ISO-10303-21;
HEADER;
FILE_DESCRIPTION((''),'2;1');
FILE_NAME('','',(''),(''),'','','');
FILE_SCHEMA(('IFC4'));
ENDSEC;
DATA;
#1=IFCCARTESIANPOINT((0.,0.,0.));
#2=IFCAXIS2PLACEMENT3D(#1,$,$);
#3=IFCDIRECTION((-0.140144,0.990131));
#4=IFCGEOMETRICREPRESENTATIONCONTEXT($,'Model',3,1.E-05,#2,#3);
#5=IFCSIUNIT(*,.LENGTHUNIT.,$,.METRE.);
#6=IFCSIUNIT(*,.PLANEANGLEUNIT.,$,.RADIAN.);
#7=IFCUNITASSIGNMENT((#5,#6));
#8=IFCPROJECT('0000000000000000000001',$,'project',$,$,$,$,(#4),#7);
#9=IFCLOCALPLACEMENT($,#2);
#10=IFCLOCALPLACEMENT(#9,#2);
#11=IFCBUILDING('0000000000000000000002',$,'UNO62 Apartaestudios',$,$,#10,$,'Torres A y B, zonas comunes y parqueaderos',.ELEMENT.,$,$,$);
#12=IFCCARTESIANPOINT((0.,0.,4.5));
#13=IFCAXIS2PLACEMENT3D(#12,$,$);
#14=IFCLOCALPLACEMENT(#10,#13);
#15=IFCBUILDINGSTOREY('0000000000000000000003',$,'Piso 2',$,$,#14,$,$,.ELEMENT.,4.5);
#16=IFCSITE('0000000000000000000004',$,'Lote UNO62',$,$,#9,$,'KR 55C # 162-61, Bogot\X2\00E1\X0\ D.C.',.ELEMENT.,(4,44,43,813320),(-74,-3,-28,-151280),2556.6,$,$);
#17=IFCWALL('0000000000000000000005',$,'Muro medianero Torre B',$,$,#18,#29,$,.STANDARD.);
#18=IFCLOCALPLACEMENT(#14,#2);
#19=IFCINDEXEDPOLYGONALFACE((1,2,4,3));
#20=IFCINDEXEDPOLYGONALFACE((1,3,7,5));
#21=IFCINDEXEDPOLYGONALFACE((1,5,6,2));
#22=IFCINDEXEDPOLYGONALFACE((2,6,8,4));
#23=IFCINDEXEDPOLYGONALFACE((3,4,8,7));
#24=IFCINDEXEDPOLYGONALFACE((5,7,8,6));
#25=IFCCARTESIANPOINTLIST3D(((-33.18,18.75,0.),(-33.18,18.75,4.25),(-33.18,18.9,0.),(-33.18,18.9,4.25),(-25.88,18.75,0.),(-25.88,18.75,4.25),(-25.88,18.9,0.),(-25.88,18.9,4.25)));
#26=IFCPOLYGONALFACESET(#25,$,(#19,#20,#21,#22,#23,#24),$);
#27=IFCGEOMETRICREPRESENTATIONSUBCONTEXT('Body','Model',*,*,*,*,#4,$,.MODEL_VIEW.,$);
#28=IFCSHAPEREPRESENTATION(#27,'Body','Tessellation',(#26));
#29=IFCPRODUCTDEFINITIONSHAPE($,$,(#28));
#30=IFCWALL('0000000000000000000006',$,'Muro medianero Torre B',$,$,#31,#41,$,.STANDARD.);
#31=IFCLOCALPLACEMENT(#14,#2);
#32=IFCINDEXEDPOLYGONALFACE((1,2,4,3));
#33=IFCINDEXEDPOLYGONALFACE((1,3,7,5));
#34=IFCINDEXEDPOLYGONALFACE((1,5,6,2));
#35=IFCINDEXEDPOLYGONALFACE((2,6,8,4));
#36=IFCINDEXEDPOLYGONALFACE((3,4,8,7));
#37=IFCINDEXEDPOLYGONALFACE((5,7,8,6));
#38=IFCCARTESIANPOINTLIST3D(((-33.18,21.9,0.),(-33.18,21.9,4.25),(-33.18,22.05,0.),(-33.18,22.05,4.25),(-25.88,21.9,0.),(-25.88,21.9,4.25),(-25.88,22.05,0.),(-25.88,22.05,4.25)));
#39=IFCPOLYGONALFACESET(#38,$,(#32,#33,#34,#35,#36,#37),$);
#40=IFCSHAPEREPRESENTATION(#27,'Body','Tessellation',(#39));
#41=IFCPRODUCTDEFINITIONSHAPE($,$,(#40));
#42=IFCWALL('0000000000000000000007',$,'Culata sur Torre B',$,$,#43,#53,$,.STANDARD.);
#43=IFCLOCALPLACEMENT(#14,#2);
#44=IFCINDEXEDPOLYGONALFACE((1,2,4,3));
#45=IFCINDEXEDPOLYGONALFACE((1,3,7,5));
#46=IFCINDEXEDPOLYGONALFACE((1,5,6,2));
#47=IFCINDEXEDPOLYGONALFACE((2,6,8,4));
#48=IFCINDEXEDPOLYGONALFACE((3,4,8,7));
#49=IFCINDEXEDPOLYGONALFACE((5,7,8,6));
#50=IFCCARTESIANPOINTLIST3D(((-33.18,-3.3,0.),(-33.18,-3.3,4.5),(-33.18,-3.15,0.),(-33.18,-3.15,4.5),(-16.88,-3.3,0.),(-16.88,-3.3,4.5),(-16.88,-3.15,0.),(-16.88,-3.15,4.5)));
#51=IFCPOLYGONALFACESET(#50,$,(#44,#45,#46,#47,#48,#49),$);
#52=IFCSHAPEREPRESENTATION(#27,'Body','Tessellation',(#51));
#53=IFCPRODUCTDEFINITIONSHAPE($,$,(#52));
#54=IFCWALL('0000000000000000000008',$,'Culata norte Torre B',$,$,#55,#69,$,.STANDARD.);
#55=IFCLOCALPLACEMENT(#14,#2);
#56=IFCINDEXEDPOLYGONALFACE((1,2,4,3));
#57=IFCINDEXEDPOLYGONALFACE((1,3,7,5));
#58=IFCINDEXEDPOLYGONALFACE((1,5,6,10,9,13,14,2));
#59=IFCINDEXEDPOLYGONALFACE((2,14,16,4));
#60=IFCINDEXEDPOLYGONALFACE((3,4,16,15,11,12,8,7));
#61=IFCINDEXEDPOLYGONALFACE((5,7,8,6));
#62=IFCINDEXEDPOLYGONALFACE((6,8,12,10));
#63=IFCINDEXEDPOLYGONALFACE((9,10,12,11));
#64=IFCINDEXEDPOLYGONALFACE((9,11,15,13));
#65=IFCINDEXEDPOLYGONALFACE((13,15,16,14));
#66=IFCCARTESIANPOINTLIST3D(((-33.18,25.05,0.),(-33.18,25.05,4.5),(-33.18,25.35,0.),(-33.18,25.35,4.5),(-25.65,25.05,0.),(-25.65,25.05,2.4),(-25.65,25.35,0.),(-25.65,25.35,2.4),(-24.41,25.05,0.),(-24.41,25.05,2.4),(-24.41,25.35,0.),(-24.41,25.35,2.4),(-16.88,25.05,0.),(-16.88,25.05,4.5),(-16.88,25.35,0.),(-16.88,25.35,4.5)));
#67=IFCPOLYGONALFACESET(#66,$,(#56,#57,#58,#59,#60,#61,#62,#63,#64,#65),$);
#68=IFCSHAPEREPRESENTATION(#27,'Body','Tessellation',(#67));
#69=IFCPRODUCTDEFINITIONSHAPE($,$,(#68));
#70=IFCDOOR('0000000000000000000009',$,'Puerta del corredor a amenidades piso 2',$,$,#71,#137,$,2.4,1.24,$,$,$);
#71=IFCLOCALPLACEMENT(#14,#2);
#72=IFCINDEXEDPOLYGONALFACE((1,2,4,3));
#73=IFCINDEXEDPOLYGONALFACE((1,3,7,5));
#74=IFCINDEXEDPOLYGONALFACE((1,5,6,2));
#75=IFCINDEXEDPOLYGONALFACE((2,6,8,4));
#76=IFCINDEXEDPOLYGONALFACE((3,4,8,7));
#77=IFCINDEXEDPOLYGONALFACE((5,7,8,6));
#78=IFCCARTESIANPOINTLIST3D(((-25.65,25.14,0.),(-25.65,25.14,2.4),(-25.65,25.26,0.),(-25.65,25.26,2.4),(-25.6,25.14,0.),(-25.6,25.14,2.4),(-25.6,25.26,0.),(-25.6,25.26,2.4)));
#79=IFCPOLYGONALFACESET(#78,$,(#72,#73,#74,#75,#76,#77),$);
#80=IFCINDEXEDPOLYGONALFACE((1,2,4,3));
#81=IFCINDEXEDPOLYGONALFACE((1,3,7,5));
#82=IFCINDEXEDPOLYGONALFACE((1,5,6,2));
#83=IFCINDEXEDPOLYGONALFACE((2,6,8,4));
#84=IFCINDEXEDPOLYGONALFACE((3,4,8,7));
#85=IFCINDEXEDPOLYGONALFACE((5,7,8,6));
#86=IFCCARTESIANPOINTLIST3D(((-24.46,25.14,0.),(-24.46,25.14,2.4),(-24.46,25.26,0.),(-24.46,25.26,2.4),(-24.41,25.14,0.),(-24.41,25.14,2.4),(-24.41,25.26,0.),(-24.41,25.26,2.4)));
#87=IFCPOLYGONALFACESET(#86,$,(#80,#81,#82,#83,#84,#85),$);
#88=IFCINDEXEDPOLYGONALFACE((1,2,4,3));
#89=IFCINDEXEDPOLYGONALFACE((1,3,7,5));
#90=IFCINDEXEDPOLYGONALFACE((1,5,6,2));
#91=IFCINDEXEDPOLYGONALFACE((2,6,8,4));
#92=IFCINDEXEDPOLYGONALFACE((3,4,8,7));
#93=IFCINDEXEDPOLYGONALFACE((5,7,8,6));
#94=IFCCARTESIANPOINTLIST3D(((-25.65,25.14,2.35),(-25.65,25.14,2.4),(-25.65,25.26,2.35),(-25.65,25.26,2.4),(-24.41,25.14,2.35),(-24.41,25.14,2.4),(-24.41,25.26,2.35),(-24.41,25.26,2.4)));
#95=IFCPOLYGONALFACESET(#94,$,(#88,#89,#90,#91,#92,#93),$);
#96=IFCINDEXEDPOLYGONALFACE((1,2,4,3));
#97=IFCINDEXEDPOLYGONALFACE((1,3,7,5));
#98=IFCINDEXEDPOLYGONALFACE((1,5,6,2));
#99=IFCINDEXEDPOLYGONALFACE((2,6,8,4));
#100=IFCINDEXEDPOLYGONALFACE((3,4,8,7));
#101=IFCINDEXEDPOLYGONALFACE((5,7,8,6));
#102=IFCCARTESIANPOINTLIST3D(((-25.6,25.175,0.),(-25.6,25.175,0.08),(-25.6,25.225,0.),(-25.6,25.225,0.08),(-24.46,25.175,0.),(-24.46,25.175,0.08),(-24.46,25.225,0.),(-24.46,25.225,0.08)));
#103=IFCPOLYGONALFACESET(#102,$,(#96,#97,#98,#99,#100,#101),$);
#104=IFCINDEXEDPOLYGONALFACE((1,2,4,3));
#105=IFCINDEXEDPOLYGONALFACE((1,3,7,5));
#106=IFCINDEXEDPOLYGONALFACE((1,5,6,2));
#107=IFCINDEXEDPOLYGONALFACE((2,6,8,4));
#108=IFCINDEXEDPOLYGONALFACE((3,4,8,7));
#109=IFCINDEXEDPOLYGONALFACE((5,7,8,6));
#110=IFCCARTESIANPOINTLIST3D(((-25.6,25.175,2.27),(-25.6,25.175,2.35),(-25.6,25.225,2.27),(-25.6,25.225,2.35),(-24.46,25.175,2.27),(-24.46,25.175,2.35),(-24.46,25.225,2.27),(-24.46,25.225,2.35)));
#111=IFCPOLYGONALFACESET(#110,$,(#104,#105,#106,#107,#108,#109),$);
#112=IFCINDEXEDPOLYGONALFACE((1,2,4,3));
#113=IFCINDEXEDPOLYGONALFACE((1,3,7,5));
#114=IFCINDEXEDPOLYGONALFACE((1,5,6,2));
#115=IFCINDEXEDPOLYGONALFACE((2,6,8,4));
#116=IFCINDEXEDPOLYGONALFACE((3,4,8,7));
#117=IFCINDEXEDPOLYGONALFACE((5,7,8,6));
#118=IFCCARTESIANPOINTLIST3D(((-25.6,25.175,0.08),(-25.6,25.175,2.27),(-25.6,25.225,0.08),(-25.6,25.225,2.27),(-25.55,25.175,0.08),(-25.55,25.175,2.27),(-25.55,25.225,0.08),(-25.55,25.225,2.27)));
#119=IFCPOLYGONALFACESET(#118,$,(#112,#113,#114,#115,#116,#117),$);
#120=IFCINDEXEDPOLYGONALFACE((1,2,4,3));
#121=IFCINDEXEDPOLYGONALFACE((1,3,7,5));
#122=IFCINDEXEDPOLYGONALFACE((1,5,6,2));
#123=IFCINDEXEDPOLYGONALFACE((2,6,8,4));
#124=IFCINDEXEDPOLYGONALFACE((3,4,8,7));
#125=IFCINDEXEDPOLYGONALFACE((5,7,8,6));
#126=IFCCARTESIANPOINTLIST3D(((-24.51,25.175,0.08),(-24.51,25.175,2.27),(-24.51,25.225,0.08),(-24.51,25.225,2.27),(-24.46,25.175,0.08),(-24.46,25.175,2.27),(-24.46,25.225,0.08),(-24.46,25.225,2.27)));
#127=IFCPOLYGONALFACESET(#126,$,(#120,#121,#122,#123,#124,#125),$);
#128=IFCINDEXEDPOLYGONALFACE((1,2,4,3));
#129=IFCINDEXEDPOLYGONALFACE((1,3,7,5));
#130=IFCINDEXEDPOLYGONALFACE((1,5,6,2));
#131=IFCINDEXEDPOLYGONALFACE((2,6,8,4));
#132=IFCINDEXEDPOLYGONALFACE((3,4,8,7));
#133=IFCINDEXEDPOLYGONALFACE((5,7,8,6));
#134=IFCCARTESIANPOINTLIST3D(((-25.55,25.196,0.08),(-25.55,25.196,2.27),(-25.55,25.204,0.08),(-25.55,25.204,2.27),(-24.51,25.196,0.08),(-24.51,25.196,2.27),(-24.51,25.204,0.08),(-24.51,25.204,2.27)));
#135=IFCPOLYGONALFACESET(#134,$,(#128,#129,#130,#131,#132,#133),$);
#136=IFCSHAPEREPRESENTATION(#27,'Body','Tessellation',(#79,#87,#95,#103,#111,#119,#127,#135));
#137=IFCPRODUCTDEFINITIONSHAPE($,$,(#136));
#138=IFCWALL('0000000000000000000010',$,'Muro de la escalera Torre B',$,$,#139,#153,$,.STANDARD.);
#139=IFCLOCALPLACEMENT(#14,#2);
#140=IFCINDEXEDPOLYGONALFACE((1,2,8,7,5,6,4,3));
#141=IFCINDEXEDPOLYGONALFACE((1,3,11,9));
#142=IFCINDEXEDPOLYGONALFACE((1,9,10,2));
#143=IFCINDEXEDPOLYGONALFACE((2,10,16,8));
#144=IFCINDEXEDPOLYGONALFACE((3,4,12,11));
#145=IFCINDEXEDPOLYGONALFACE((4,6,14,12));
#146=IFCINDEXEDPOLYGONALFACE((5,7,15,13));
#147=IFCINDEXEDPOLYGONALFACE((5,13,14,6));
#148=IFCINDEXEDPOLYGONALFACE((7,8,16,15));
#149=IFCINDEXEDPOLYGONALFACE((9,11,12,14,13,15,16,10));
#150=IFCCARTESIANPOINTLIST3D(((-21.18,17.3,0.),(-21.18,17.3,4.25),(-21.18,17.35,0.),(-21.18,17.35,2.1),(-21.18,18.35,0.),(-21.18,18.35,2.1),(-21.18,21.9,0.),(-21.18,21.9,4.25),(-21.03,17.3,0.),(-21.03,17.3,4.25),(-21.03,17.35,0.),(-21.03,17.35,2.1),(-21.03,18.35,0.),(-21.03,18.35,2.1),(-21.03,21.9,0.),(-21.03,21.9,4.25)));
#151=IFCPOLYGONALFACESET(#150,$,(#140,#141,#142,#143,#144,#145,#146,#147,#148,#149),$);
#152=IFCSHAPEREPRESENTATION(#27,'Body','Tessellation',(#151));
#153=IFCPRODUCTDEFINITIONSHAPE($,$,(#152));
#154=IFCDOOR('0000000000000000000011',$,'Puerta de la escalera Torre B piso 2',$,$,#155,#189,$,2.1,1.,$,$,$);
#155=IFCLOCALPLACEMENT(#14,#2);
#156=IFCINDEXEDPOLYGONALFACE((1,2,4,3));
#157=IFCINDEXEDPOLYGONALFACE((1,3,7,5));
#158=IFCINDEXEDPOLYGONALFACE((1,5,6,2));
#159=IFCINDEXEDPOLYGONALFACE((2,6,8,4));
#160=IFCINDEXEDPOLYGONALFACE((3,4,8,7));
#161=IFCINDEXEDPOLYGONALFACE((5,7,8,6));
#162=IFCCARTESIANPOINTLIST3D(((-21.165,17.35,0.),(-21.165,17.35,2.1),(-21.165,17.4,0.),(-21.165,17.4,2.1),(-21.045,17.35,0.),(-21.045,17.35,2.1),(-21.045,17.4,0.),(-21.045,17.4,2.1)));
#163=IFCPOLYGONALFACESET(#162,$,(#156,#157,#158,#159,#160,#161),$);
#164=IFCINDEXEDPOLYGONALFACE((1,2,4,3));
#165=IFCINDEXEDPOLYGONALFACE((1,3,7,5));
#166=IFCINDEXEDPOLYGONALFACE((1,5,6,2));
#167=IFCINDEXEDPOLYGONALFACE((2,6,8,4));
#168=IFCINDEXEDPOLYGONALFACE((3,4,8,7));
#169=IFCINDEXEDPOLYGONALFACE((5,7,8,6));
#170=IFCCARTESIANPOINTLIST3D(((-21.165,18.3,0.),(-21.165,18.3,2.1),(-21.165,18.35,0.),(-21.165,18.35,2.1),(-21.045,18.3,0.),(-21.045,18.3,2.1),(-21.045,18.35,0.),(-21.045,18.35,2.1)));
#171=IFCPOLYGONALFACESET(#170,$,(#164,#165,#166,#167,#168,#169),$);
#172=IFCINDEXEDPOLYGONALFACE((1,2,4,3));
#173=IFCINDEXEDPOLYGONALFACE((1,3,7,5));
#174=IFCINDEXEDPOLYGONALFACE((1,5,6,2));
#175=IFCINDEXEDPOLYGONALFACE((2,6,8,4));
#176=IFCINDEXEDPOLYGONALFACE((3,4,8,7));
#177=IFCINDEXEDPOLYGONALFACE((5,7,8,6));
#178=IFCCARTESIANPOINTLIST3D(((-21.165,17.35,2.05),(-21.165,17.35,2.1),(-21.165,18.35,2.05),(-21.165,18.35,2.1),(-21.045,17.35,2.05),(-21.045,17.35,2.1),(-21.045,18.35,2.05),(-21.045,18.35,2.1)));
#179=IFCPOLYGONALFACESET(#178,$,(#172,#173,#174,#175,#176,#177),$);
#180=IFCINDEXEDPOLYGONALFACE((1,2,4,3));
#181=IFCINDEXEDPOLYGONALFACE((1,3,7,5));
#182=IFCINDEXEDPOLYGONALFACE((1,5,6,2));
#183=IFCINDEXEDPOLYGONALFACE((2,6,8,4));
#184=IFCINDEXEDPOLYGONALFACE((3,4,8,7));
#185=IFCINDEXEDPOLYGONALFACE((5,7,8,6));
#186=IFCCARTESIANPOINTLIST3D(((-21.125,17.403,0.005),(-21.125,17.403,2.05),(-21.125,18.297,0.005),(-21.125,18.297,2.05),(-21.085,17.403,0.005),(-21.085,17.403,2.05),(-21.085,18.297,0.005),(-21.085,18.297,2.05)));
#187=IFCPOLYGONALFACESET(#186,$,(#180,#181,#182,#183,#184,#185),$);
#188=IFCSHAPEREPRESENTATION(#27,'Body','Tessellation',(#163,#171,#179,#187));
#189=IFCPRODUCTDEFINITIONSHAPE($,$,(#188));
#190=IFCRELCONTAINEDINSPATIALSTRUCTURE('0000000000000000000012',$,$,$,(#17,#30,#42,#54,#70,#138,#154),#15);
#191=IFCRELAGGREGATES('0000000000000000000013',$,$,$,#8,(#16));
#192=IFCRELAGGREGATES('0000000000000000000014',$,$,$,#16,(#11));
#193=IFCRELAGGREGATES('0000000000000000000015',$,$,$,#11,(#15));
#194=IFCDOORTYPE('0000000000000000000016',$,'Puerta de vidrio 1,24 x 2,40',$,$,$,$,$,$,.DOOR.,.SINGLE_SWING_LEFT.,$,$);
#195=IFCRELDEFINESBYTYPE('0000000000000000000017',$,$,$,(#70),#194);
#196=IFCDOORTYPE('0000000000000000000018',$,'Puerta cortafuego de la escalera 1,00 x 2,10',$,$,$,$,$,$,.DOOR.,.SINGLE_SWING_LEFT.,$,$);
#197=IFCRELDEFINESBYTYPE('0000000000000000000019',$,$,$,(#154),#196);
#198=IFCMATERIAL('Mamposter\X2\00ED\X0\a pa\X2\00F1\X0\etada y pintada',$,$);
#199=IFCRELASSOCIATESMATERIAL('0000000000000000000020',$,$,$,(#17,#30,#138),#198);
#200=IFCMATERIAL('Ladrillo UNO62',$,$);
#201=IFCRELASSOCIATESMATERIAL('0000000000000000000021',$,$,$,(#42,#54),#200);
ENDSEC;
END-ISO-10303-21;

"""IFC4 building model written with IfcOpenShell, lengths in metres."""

from ifc_helpers import new_model, si_unit, direction, frame, frame_2d, origin, place, context, subcontext, project, spatial, rectangle, extrude, source, transform, mapped, material, type_object, type_shapes, element, fill, save


model = new_model("IFC4")

# Units and contexts
model_context = context("Model", 3, precision=1e-05, world=origin(), true_north=direction((-0.140144, 0.990131)))
body_context = subcontext(model_context, "Body", "Model", "MODEL_VIEW")
ifc_project = project(units=[si_unit("LENGTHUNIT", "METRE"), si_unit("PLANEANGLEUNIT", "RADIAN")], contexts=[model_context])

# Site, building, storey
site_placement = place(None, origin())
site = spatial("IfcSite", under=ifc_project, at=site_placement, Name="Lote UNO62", LongName="KR 55C # 162-61, Bogotá D.C.", CompositionType="ELEMENT", RefLatitude=(4, 44, 43, 813320), RefLongitude=(-74, -3, -28, -151280), RefElevation=2556.6)
building_placement = place(site_placement, origin())
building = spatial("IfcBuilding", under=site, at=building_placement, Name="UNO62 Apartaestudios", LongName="Torres A y B, zonas comunes y parqueaderos", CompositionType="ELEMENT")
storey_placement = place(building_placement, frame((0.0, 0.0, 4.5)))
storey = spatial("IfcBuildingStorey", under=building, at=storey_placement, Name="Piso 2", CompositionType="ELEMENT", Elevation=4.5)

# Shared definitions
ifc_material_1 = material(Name="Ladrillo UNO62")

# Walls
ifc_material_2 = material(Name="Mampostería pañetada y pintada")
wall_1_placement = place(storey_placement, origin())
element("IfcWall", 1, at=wall_1_placement, inside=storey, material=ifc_material_2, Name="Muro medianero Torre B", PredefinedType="STANDARD", context=body_context, shape_type="SweptSolid", body=[
    extrude(rectangle(XDim=7.3, YDim=0.15, at=frame_2d((-29.53, 18.825))), origin(), (0.0, 0.0, 1.0), 4.25),
])
wall_2_placement = place(storey_placement, origin())
element("IfcWall", 2, at=wall_2_placement, inside=storey, material=ifc_material_2, Name="Muro medianero Torre B", PredefinedType="STANDARD", context=body_context, shape_type="SweptSolid", body=[
    extrude(rectangle(XDim=7.3, YDim=0.15, at=frame_2d((-29.53, 21.975))), origin(), (0.0, 0.0, 1.0), 4.25),
])
wall_3_placement = place(storey_placement, origin())
element("IfcWall", 3, at=wall_3_placement, inside=storey, material=ifc_material_1, Name="Culata sur Torre B", PredefinedType="STANDARD", context=body_context, shape_type="SweptSolid", body=[
    extrude(rectangle(XDim=16.3, YDim=0.15, at=frame_2d((-25.03, -3.225))), origin(), (0.0, 0.0, 1.0), 4.5),
])

# Walls, openings, doors
wall_4_placement = place(storey_placement, origin())
wall_4 = element("IfcWall", 4, at=wall_4_placement, inside=storey, material=ifc_material_1, Name="Culata norte Torre B", PredefinedType="STANDARD", context=body_context, shape_type="SweptSolid", body=[
    extrude(rectangle(XDim=16.3, YDim=0.3, at=frame_2d((-25.03, 25.2))), origin(), (0.0, 0.0, 1.0), 4.5),
])
opening_1_placement = place(wall_4_placement, origin())
opening_1 = element("IfcOpeningElement", 5, at=opening_1_placement, cuts=wall_4, PredefinedType="OPENING", context=body_context, shape_type="SweptSolid", body=[
    extrude(rectangle(XDim=1.24, YDim=0.4, at=frame_2d((-25.03, 25.2))), origin(), (0.0, 0.0, 1.0), 2.4),
])
door_type_1 = type_object("IfcDoorType", Name="Puerta de vidrio 1,24 x 2,40", OperationType="SINGLE_SWING_LEFT", PredefinedType="DOOR")
shared_shape_1 = source(origin(), body_context, "Body", "SweptSolid", [
    extrude(rectangle(XDim=0.05, YDim=0.12, at=frame_2d((0.025, 0.0))), origin(), (0.0, 0.0, 1.0), 2.4),
    extrude(rectangle(XDim=0.05, YDim=0.12, at=frame_2d((1.215, 0.0))), origin(), (0.0, 0.0, 1.0), 2.4),
    extrude(rectangle(XDim=1.24, YDim=0.12, at=frame_2d((0.62, 0.0))), frame((0.0, 0.0, 2.35)), (0.0, 0.0, 1.0), 0.05),
    extrude(rectangle(XDim=1.14, YDim=0.05, at=frame_2d((0.62, 0.0))), origin(), (0.0, 0.0, 1.0), 0.08),
    extrude(rectangle(XDim=1.14, YDim=0.05, at=frame_2d((0.62, 0.0))), frame((0.0, 0.0, 2.27)), (0.0, 0.0, 1.0), 0.08),
    extrude(rectangle(XDim=0.05, YDim=0.05, at=frame_2d((0.075, 0.0))), frame((0.0, 0.0, 0.08)), (0.0, 0.0, 1.0), 2.19),
    extrude(rectangle(XDim=0.05, YDim=0.05, at=frame_2d((1.165, 0.0))), frame((0.0, 0.0, 0.08)), (0.0, 0.0, 1.0), 2.19),
    extrude(rectangle(XDim=1.04, YDim=0.008, at=frame_2d((0.62, 0.0))), frame((0.0, 0.0, 0.08)), (0.0, 0.0, 1.0), 2.19),
])
type_shapes(door_type_1, [shared_shape_1])
door_1_placement = place(storey_placement, frame((-25.65, 25.2, 0.0), z_axis=(0.0, 0.0, 1.0), x_axis=(1.0, 0.0, 0.0)))
door_1 = element("IfcDoor", 6, at=door_1_placement, inside=storey, type_object=door_type_1, Name="Puerta del corredor a amenidades piso 2", OverallHeight=2.4, OverallWidth=1.24, context=body_context, shape_type="MappedRepresentation", body=[
    mapped(shared_shape_1, transform((0.0, 0.0, 0.0))),
])
fill(opening_1, door_1)
wall_5_placement = place(storey_placement, origin())
wall_5 = element("IfcWall", 7, at=wall_5_placement, inside=storey, material=ifc_material_2, Name="Muro de la escalera Torre B", PredefinedType="STANDARD", context=body_context, shape_type="SweptSolid", body=[
    extrude(rectangle(XDim=0.15, YDim=4.6, at=frame_2d((-21.105, 19.6))), origin(), (0.0, 0.0, 1.0), 4.25),
])
opening_2_placement = place(wall_5_placement, origin())
opening_2 = element("IfcOpeningElement", 8, at=opening_2_placement, cuts=wall_5, PredefinedType="OPENING", context=body_context, shape_type="SweptSolid", body=[
    extrude(rectangle(XDim=0.25, YDim=1.0, at=frame_2d((-21.105, 17.85))), origin(), (0.0, 0.0, 1.0), 2.1),
])
door_type_2 = type_object("IfcDoorType", Name="Puerta cortafuego de la escalera 1,00 x 2,10", OperationType="SINGLE_SWING_LEFT", PredefinedType="DOOR")
shared_shape_2 = source(origin(), body_context, "Body", "SweptSolid", [
    extrude(rectangle(XDim=0.05, YDim=0.12, at=frame_2d((0.025, 0.0))), origin(), (0.0, 0.0, 1.0), 2.1),
    extrude(rectangle(XDim=0.05, YDim=0.12, at=frame_2d((0.975, 0.0))), origin(), (0.0, 0.0, 1.0), 2.1),
    extrude(rectangle(XDim=1.0, YDim=0.12, at=frame_2d((0.5, 0.0))), frame((0.0, 0.0, 2.05)), (0.0, 0.0, 1.0), 0.05),
    extrude(rectangle(XDim=0.894, YDim=0.04, at=frame_2d((0.5, 0.0))), frame((0.0, 0.0, 0.005)), (0.0, 0.0, 1.0), 2.045),
])
type_shapes(door_type_2, [shared_shape_2])
door_2_placement = place(storey_placement, frame((-21.105, 17.35, 0.0), z_axis=(0.0, 0.0, 1.0), x_axis=(0.0, 1.0, 0.0)))
door_2 = element("IfcDoor", 9, at=door_2_placement, inside=storey, type_object=door_type_2, Name="Puerta de la escalera Torre B piso 2", OverallHeight=2.1, OverallWidth=1.0, context=body_context, shape_type="MappedRepresentation", body=[
    mapped(shared_shape_2, transform((0.0, 0.0, 0.0))),
])
fill(opening_2, door_2)

save(model, "model.ifc")
